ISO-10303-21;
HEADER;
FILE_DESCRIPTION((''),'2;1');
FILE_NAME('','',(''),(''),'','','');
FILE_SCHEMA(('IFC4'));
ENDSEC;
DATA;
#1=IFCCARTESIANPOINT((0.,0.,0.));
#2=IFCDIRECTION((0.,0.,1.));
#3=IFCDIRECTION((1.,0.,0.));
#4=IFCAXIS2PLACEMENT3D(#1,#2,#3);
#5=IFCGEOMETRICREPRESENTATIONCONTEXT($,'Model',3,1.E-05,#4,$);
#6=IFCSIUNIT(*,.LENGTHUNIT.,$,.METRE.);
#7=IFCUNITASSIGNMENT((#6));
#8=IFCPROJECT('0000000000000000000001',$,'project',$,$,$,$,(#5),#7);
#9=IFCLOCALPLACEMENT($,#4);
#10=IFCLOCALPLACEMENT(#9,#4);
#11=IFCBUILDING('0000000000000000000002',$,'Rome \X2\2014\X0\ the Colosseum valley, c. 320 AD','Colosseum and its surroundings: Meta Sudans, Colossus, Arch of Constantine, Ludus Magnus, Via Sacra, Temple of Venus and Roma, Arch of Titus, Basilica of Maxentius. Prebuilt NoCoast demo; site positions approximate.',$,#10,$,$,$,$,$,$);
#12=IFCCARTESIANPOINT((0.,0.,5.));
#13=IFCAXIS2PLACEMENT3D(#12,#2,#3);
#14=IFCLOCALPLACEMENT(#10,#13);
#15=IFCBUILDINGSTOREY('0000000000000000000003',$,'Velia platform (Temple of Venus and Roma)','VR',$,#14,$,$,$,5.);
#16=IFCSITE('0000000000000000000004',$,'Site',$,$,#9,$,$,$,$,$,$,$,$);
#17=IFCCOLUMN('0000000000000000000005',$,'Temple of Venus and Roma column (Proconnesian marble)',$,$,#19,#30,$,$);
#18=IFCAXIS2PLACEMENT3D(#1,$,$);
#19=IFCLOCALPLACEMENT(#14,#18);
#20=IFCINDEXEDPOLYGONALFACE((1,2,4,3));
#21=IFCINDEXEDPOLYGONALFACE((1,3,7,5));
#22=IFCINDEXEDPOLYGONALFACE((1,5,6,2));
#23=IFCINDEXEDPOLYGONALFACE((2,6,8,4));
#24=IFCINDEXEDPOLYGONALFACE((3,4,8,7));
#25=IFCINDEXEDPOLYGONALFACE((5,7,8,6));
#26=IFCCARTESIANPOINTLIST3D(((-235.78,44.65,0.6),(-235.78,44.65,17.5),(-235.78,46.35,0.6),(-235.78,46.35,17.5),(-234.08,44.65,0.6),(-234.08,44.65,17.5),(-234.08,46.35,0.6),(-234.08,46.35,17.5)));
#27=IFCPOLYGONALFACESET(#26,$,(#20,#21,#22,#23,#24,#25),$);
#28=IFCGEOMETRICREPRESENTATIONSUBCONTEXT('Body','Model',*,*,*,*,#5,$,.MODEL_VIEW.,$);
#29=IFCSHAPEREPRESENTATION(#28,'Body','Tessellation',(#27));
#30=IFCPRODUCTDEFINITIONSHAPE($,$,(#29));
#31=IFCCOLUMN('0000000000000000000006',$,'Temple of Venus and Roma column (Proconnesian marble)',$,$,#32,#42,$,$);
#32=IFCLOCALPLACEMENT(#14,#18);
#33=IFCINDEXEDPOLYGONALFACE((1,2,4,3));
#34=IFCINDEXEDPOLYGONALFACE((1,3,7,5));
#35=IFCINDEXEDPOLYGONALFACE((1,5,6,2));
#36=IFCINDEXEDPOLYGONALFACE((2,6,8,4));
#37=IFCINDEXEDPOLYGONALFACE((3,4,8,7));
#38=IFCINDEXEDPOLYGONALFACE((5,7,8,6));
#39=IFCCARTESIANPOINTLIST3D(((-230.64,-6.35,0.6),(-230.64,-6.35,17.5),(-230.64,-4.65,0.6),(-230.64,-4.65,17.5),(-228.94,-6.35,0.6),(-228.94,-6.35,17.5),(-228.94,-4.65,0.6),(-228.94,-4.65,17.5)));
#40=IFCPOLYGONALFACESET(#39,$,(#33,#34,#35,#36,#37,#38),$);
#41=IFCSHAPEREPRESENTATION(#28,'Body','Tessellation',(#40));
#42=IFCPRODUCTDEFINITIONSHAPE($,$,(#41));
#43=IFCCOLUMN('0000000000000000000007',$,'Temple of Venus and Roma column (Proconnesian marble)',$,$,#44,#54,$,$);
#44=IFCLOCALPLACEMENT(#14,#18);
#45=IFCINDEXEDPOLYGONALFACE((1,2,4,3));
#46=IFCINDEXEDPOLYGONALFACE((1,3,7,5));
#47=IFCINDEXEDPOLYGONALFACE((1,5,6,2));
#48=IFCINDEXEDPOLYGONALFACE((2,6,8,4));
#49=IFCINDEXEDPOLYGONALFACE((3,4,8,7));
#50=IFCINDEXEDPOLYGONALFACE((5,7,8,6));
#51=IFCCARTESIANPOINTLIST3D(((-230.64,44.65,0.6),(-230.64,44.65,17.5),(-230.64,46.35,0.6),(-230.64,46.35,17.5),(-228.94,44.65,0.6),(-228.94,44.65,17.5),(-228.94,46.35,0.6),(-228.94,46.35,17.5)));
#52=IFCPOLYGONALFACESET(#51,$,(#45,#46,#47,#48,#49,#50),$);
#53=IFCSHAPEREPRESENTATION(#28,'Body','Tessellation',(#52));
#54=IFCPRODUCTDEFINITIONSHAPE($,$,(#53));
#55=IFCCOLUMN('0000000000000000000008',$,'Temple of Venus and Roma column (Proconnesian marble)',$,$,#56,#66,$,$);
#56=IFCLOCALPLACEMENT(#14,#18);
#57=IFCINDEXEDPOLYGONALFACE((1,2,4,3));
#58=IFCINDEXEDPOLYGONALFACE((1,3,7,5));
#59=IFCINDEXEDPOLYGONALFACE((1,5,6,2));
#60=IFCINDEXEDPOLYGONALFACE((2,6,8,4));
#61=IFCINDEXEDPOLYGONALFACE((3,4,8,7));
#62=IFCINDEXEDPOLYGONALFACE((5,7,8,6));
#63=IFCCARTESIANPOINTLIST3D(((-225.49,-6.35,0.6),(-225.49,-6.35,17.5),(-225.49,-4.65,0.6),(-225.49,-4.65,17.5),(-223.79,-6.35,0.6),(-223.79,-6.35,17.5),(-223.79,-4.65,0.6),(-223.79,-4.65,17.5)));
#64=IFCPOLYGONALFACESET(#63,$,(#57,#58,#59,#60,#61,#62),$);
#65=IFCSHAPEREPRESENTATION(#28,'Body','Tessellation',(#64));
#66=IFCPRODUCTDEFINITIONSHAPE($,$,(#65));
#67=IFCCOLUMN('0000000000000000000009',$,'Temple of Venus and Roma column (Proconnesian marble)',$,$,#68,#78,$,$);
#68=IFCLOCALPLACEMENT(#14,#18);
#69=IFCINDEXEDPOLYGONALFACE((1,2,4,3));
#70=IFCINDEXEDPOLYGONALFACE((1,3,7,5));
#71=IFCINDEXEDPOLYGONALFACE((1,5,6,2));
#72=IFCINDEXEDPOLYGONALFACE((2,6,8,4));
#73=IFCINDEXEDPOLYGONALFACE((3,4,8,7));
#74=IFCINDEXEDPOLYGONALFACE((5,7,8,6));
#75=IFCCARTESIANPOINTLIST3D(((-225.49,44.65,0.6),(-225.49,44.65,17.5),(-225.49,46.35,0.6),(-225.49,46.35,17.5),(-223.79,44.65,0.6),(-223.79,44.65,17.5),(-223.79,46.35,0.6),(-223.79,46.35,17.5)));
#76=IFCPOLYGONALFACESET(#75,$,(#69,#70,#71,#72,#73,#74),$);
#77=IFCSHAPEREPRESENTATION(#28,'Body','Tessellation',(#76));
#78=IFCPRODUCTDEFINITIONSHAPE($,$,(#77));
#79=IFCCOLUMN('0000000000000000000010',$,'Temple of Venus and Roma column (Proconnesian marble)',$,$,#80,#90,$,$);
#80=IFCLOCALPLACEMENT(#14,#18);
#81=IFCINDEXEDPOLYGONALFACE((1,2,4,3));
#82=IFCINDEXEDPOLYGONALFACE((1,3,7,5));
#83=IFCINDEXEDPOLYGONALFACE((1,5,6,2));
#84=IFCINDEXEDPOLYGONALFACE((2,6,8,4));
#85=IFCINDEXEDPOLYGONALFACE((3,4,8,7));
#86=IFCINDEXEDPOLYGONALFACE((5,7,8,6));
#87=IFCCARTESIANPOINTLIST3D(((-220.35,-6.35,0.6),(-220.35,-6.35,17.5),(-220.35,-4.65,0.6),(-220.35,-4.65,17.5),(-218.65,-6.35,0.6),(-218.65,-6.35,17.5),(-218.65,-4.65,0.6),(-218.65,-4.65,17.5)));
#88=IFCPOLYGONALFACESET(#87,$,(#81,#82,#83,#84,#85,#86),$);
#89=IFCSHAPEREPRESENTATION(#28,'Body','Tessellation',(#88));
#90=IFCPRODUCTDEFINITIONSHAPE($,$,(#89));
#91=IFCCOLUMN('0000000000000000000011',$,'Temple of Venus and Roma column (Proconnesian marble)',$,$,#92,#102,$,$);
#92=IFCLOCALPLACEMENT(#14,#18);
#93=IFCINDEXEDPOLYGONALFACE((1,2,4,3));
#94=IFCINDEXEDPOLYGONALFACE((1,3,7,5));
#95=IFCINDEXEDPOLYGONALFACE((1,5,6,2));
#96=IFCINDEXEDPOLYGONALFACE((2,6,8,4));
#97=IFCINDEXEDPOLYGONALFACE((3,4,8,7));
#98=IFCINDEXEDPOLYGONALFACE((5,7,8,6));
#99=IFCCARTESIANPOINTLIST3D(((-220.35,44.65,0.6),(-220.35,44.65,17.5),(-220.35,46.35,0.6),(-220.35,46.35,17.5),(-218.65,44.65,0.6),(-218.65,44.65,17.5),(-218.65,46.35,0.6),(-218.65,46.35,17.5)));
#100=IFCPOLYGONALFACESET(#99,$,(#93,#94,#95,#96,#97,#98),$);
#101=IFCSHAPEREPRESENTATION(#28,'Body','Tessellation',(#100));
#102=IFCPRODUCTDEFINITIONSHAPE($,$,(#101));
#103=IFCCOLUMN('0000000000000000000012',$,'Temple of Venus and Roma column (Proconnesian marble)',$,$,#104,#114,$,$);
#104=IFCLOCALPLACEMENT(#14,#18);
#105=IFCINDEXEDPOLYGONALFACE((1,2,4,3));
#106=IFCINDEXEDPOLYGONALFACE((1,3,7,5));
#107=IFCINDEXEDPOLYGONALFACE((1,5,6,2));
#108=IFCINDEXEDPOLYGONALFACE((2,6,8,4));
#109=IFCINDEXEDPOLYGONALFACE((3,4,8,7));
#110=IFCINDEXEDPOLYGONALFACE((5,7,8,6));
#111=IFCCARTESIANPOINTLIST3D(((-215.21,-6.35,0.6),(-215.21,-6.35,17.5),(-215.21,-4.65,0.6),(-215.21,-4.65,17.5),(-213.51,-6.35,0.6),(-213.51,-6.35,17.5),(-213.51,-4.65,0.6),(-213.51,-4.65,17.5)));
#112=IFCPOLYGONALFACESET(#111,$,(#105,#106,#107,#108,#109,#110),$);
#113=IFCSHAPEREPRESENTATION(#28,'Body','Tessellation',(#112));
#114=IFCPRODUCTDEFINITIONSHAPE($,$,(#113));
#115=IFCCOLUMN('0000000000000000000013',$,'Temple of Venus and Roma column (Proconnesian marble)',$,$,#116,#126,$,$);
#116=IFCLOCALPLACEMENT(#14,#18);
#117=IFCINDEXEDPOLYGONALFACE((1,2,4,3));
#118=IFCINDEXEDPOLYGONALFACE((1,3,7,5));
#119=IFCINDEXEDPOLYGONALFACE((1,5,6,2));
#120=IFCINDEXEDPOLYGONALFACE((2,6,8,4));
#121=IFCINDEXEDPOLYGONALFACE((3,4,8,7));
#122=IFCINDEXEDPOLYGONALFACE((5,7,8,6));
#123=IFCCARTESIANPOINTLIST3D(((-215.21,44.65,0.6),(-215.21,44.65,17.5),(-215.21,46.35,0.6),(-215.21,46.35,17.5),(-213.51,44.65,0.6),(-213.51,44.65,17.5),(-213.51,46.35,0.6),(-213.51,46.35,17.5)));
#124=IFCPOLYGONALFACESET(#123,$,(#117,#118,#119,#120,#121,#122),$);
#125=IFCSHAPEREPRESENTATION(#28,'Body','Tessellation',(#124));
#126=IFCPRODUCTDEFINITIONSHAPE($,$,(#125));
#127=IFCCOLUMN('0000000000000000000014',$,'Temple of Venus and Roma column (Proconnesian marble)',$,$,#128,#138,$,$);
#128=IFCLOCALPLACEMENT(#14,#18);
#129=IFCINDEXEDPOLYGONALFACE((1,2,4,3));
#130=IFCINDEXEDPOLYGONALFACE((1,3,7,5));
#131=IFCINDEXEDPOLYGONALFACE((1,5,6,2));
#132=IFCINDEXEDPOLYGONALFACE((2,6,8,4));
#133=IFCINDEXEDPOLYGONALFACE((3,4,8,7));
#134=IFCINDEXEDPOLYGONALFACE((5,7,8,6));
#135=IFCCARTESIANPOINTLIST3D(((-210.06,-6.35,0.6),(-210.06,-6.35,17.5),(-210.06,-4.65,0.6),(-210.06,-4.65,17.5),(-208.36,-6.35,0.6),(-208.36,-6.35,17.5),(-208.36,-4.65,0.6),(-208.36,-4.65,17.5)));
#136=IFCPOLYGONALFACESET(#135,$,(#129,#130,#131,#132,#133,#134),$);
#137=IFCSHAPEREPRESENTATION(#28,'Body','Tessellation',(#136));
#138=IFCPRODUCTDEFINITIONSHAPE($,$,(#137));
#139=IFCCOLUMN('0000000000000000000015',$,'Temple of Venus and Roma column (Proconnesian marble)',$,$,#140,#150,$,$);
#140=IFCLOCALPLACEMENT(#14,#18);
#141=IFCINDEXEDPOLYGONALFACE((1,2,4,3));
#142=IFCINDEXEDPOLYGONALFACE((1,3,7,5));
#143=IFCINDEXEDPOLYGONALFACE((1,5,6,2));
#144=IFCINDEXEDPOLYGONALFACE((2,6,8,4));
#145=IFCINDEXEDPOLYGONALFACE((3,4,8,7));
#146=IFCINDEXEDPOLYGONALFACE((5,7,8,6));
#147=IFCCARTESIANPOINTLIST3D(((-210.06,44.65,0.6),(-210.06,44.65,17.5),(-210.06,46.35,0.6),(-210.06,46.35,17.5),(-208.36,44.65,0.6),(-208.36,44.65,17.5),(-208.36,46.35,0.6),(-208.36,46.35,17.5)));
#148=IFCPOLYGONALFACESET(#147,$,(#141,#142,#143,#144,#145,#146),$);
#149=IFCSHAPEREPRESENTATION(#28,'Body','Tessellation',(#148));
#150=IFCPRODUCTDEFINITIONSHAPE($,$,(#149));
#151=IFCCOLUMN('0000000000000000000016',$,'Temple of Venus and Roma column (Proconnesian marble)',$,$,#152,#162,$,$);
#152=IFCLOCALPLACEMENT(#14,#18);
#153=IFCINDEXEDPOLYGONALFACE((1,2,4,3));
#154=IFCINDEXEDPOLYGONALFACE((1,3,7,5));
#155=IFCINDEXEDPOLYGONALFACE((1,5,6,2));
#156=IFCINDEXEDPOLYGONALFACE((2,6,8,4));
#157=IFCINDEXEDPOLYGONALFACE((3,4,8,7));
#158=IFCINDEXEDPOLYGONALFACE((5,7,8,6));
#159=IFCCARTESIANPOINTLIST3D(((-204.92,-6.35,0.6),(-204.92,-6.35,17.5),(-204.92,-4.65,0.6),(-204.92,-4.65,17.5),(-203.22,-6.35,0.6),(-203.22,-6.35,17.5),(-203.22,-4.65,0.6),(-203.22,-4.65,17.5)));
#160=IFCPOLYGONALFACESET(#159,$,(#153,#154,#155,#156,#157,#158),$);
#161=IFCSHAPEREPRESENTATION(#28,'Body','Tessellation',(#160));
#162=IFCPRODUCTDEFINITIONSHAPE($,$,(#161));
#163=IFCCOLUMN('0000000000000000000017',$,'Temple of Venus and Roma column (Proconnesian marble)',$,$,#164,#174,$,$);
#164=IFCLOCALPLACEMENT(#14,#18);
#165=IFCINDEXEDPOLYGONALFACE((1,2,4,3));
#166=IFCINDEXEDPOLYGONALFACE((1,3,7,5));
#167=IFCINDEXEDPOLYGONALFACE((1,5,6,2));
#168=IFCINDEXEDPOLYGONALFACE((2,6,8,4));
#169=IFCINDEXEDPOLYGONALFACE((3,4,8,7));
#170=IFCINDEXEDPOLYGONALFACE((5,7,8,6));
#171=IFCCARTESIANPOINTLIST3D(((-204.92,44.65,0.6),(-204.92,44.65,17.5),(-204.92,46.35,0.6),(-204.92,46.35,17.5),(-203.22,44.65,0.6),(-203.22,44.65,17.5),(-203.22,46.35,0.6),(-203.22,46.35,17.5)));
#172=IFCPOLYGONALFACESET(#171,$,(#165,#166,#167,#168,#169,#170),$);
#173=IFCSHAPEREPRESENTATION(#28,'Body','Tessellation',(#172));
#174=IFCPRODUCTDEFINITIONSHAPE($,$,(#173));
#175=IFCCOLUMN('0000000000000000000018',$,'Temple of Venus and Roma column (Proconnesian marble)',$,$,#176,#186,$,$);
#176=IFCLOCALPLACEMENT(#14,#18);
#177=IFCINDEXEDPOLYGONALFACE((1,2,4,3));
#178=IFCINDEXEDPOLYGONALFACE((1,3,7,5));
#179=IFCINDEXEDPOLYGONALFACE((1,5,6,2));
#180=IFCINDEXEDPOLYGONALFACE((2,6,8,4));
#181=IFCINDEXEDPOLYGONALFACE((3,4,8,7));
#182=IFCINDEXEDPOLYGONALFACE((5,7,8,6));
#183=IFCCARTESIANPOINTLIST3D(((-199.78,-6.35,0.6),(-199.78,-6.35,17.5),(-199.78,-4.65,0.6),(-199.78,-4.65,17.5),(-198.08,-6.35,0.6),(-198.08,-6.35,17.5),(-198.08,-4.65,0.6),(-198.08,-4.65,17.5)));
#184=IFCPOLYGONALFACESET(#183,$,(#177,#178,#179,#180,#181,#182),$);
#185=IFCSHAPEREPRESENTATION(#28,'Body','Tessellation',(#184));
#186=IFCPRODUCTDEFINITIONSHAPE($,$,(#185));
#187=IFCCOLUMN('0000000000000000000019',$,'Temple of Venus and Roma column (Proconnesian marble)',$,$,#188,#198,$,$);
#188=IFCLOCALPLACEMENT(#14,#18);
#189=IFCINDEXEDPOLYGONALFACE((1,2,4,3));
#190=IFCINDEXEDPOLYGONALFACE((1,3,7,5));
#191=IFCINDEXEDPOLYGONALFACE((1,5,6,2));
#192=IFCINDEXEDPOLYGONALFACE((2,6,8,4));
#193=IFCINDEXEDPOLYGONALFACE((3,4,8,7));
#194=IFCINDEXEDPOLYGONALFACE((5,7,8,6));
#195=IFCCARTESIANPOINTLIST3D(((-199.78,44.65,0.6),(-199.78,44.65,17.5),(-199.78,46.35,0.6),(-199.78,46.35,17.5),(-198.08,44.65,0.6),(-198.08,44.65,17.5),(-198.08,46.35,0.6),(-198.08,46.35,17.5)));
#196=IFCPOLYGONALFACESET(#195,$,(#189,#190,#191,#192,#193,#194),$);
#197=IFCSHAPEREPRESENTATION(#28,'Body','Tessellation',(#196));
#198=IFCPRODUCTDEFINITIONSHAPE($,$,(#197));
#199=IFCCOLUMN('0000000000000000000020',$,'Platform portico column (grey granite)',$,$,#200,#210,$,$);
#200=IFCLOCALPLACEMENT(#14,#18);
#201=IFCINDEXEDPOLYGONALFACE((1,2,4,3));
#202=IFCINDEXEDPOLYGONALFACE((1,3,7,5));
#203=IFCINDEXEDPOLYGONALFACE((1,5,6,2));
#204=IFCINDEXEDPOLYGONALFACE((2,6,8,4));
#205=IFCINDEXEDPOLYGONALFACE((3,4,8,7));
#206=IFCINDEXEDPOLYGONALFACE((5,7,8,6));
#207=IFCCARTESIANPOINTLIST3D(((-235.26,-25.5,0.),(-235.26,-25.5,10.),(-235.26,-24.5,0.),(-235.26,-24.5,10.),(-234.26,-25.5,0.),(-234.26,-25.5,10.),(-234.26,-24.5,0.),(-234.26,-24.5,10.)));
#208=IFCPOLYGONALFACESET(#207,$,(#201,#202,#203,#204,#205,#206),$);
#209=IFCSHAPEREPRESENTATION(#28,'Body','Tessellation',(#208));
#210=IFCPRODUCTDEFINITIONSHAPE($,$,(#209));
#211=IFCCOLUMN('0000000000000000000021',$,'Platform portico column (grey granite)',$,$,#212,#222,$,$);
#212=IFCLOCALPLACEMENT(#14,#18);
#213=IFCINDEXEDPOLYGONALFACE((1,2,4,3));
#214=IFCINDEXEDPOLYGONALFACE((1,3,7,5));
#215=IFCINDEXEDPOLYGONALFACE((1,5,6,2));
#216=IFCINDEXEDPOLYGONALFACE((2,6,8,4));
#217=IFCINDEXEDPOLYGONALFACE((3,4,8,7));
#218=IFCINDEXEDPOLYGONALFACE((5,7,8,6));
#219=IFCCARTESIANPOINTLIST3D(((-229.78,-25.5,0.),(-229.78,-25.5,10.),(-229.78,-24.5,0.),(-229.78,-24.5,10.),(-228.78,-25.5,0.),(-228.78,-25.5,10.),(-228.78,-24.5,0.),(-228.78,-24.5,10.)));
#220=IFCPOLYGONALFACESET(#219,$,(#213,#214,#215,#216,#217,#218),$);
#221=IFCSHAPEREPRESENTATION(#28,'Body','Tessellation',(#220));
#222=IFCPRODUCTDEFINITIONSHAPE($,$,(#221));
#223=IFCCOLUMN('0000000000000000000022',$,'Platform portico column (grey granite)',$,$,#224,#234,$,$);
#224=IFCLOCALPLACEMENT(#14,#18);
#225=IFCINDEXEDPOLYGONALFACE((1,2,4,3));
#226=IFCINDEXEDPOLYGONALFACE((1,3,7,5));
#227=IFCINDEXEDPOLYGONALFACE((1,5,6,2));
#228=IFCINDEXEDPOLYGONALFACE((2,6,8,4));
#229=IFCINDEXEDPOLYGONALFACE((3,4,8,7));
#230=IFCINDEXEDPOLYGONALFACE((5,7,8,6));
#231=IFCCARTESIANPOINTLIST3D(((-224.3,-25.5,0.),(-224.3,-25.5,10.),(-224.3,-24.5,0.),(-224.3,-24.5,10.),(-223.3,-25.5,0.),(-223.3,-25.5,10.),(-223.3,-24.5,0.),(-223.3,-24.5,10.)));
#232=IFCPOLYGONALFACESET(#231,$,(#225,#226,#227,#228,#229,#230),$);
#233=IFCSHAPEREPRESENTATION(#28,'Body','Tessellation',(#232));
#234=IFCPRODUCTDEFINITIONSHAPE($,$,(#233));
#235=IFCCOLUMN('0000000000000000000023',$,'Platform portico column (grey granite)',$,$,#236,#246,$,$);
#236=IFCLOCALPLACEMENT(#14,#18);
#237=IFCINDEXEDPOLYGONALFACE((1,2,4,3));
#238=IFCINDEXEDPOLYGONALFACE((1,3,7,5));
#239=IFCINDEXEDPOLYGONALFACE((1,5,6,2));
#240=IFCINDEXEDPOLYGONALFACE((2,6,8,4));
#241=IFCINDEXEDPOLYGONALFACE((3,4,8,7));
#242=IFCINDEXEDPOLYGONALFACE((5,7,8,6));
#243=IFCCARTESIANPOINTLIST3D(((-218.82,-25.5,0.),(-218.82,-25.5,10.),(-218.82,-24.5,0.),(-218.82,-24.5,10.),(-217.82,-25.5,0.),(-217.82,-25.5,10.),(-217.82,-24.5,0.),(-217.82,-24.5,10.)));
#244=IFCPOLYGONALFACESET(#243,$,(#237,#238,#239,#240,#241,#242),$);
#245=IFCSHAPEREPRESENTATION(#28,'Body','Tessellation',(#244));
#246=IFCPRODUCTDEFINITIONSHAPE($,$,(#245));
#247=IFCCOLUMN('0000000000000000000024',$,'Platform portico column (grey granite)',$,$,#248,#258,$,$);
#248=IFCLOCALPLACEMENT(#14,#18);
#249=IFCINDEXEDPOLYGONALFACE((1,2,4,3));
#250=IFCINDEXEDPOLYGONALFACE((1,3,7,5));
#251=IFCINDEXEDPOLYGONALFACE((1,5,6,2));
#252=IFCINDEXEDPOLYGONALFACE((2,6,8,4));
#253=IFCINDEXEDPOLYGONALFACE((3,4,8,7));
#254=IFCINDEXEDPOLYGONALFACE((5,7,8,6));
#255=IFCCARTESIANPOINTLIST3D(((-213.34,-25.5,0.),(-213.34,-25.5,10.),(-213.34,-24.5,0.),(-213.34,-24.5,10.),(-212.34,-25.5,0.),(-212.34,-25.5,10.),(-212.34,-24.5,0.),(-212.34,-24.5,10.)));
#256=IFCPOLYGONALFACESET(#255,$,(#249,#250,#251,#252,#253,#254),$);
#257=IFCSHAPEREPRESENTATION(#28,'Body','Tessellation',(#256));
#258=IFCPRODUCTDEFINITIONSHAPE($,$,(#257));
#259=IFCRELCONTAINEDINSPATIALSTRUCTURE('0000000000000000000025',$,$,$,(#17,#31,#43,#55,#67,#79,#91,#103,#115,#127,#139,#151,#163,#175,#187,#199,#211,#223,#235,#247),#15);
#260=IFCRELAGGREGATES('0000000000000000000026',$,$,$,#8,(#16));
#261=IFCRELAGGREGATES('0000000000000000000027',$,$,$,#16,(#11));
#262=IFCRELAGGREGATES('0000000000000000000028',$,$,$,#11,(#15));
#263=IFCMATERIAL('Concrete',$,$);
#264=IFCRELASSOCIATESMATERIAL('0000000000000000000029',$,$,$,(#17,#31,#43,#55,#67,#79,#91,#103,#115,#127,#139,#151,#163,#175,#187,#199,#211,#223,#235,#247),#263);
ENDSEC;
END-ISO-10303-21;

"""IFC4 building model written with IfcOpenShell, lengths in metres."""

from ifc_helpers import new_model, si_unit, frame, origin_with_axes, place, context, subcontext, project, spatial, indexed_curve, outline, extrude, material, element, save


model = new_model("IFC4")

# Units and contexts
model_context = context("Model", 3, precision=1e-05, world=origin_with_axes())
body_context = subcontext(model_context, "Body", "Model", "MODEL_VIEW")
ifc_project = project(units=[si_unit("LENGTHUNIT", "METRE")], contexts=[model_context])

# Site, building, storey
site_placement = place(None, origin_with_axes())
site = spatial("IfcSite", under=ifc_project, at=site_placement, Name="Site")
building_placement = place(site_placement, origin_with_axes())
building = spatial("IfcBuilding", under=site, at=building_placement, Name="Rome — the Colosseum valley, c. 320 AD", Description="Colosseum and its surroundings: Meta Sudans, Colossus, Arch of Constantine, Ludus Magnus, Via Sacra, Temple of Venus and Roma, Arch of Titus, Basilica of Maxentius. Prebuilt NoCoast demo; site positions approximate.")
storey_placement = place(building_placement, frame((0.0, 0.0, 5.0), z_axis=(0.0, 0.0, 1.0), x_axis=(1.0, 0.0, 0.0)))
storey = spatial("IfcBuildingStorey", under=building, at=storey_placement, Name="Velia platform (Temple of Venus and Roma)", Description="VR", Elevation=5.0)

# Columns
ifc_material_1 = material(Name="Concrete")
for number, where, z_axis, x_axis, name in (
    (1, (-235.78, 45.5, 0.6), (0.0, 0.0, 1.0), (1.0, 0.0, 0.0), "Temple of Venus and Roma column (Proconnesian marble)"),
    (2, (-230.64, -5.5, 0.6), (0.0, 0.0, 1.0), (1.0, 0.0, 0.0), "Temple of Venus and Roma column (Proconnesian marble)"),
    (3, (-230.64, 45.5, 0.6), (0.0, 0.0, 1.0), (1.0, 0.0, 0.0), "Temple of Venus and Roma column (Proconnesian marble)"),
    (4, (-225.49, -5.5, 0.6), (0.0, 0.0, 1.0), (1.0, 0.0, 0.0), "Temple of Venus and Roma column (Proconnesian marble)"),
    (5, (-225.49, 45.5, 0.6), (0.0, 0.0, 1.0), (1.0, 0.0, 0.0), "Temple of Venus and Roma column (Proconnesian marble)"),
    (6, (-220.35, -5.5, 0.6), (0.0, 0.0, 1.0), (1.0, 0.0, 0.0), "Temple of Venus and Roma column (Proconnesian marble)"),
    (7, (-220.35, 45.5, 0.6), (0.0, 0.0, 1.0), (1.0, 0.0, 0.0), "Temple of Venus and Roma column (Proconnesian marble)"),
    (8, (-215.21, -5.5, 0.6), (0.0, 0.0, 1.0), (1.0, 0.0, 0.0), "Temple of Venus and Roma column (Proconnesian marble)"),
    (9, (-215.21, 45.5, 0.6), (0.0, 0.0, 1.0), (1.0, 0.0, 0.0), "Temple of Venus and Roma column (Proconnesian marble)"),
    (10, (-210.06, -5.5, 0.6), (0.0, 0.0, 1.0), (1.0, 0.0, 0.0), "Temple of Venus and Roma column (Proconnesian marble)"),
    (11, (-210.06, 45.5, 0.6), (0.0, 0.0, 1.0), (1.0, 0.0, 0.0), "Temple of Venus and Roma column (Proconnesian marble)"),
    (12, (-204.92, -5.5, 0.6), (0.0, 0.0, 1.0), (1.0, 0.0, 0.0), "Temple of Venus and Roma column (Proconnesian marble)"),
    (13, (-204.92, 45.5, 0.6), (0.0, 0.0, 1.0), (1.0, 0.0, 0.0), "Temple of Venus and Roma column (Proconnesian marble)"),
    (14, (-199.78, -5.5, 0.6), (0.0, 0.0, 1.0), (1.0, 0.0, 0.0), "Temple of Venus and Roma column (Proconnesian marble)"),
    (15, (-199.78, 45.5, 0.6), (0.0, 0.0, 1.0), (1.0, 0.0, 0.0), "Temple of Venus and Roma column (Proconnesian marble)"),
):
    element("IfcColumn", number, at=place(storey_placement, frame(where, z_axis=z_axis, x_axis=x_axis)), inside=storey, material=ifc_material_1, Name=name, context=body_context, shape_type="SweptSolid", body=[
        extrude(outline(indexed_curve([(0.0, 0.0), (0.0, 1.7), (1.7, 1.7), (1.7, 0.0), (0.0, 0.0)], self_intersect=False)), frame((0.0, -0.85, 0.0), z_axis=(0.0, 0.0, 1.0), x_axis=(1.0, 0.0, 0.0)), (0.0, 0.0, 1.0), 16.9),
    ])
for number, where, z_axis, x_axis, name in (
    (16, (-235.26, -25.0, 0.0), (0.0, 0.0, 1.0), (1.0, 0.0, 0.0), "Platform portico column (grey granite)"),
    (17, (-229.78, -25.0, 0.0), (0.0, 0.0, 1.0), (1.0, 0.0, 0.0), "Platform portico column (grey granite)"),
    (18, (-224.3, -25.0, 0.0), (0.0, 0.0, 1.0), (1.0, 0.0, 0.0), "Platform portico column (grey granite)"),
    (19, (-218.82, -25.0, 0.0), (0.0, 0.0, 1.0), (1.0, 0.0, 0.0), "Platform portico column (grey granite)"),
    (20, (-213.34, -25.0, 0.0), (0.0, 0.0, 1.0), (1.0, 0.0, 0.0), "Platform portico column (grey granite)"),
):
    element("IfcColumn", number, at=place(storey_placement, frame(where, z_axis=z_axis, x_axis=x_axis)), inside=storey, material=ifc_material_1, Name=name, context=body_context, shape_type="SweptSolid", body=[
        extrude(outline(indexed_curve([(0.0, 0.0), (0.0, 1.0), (1.0, 1.0), (1.0, 0.0), (0.0, 0.0)], self_intersect=False)), frame((0.0, -0.5, 0.0), z_axis=(0.0, 0.0, 1.0), x_axis=(1.0, 0.0, 0.0)), (0.0, 0.0, 1.0), 10.0),
    ])

save(model, "model.ifc")
